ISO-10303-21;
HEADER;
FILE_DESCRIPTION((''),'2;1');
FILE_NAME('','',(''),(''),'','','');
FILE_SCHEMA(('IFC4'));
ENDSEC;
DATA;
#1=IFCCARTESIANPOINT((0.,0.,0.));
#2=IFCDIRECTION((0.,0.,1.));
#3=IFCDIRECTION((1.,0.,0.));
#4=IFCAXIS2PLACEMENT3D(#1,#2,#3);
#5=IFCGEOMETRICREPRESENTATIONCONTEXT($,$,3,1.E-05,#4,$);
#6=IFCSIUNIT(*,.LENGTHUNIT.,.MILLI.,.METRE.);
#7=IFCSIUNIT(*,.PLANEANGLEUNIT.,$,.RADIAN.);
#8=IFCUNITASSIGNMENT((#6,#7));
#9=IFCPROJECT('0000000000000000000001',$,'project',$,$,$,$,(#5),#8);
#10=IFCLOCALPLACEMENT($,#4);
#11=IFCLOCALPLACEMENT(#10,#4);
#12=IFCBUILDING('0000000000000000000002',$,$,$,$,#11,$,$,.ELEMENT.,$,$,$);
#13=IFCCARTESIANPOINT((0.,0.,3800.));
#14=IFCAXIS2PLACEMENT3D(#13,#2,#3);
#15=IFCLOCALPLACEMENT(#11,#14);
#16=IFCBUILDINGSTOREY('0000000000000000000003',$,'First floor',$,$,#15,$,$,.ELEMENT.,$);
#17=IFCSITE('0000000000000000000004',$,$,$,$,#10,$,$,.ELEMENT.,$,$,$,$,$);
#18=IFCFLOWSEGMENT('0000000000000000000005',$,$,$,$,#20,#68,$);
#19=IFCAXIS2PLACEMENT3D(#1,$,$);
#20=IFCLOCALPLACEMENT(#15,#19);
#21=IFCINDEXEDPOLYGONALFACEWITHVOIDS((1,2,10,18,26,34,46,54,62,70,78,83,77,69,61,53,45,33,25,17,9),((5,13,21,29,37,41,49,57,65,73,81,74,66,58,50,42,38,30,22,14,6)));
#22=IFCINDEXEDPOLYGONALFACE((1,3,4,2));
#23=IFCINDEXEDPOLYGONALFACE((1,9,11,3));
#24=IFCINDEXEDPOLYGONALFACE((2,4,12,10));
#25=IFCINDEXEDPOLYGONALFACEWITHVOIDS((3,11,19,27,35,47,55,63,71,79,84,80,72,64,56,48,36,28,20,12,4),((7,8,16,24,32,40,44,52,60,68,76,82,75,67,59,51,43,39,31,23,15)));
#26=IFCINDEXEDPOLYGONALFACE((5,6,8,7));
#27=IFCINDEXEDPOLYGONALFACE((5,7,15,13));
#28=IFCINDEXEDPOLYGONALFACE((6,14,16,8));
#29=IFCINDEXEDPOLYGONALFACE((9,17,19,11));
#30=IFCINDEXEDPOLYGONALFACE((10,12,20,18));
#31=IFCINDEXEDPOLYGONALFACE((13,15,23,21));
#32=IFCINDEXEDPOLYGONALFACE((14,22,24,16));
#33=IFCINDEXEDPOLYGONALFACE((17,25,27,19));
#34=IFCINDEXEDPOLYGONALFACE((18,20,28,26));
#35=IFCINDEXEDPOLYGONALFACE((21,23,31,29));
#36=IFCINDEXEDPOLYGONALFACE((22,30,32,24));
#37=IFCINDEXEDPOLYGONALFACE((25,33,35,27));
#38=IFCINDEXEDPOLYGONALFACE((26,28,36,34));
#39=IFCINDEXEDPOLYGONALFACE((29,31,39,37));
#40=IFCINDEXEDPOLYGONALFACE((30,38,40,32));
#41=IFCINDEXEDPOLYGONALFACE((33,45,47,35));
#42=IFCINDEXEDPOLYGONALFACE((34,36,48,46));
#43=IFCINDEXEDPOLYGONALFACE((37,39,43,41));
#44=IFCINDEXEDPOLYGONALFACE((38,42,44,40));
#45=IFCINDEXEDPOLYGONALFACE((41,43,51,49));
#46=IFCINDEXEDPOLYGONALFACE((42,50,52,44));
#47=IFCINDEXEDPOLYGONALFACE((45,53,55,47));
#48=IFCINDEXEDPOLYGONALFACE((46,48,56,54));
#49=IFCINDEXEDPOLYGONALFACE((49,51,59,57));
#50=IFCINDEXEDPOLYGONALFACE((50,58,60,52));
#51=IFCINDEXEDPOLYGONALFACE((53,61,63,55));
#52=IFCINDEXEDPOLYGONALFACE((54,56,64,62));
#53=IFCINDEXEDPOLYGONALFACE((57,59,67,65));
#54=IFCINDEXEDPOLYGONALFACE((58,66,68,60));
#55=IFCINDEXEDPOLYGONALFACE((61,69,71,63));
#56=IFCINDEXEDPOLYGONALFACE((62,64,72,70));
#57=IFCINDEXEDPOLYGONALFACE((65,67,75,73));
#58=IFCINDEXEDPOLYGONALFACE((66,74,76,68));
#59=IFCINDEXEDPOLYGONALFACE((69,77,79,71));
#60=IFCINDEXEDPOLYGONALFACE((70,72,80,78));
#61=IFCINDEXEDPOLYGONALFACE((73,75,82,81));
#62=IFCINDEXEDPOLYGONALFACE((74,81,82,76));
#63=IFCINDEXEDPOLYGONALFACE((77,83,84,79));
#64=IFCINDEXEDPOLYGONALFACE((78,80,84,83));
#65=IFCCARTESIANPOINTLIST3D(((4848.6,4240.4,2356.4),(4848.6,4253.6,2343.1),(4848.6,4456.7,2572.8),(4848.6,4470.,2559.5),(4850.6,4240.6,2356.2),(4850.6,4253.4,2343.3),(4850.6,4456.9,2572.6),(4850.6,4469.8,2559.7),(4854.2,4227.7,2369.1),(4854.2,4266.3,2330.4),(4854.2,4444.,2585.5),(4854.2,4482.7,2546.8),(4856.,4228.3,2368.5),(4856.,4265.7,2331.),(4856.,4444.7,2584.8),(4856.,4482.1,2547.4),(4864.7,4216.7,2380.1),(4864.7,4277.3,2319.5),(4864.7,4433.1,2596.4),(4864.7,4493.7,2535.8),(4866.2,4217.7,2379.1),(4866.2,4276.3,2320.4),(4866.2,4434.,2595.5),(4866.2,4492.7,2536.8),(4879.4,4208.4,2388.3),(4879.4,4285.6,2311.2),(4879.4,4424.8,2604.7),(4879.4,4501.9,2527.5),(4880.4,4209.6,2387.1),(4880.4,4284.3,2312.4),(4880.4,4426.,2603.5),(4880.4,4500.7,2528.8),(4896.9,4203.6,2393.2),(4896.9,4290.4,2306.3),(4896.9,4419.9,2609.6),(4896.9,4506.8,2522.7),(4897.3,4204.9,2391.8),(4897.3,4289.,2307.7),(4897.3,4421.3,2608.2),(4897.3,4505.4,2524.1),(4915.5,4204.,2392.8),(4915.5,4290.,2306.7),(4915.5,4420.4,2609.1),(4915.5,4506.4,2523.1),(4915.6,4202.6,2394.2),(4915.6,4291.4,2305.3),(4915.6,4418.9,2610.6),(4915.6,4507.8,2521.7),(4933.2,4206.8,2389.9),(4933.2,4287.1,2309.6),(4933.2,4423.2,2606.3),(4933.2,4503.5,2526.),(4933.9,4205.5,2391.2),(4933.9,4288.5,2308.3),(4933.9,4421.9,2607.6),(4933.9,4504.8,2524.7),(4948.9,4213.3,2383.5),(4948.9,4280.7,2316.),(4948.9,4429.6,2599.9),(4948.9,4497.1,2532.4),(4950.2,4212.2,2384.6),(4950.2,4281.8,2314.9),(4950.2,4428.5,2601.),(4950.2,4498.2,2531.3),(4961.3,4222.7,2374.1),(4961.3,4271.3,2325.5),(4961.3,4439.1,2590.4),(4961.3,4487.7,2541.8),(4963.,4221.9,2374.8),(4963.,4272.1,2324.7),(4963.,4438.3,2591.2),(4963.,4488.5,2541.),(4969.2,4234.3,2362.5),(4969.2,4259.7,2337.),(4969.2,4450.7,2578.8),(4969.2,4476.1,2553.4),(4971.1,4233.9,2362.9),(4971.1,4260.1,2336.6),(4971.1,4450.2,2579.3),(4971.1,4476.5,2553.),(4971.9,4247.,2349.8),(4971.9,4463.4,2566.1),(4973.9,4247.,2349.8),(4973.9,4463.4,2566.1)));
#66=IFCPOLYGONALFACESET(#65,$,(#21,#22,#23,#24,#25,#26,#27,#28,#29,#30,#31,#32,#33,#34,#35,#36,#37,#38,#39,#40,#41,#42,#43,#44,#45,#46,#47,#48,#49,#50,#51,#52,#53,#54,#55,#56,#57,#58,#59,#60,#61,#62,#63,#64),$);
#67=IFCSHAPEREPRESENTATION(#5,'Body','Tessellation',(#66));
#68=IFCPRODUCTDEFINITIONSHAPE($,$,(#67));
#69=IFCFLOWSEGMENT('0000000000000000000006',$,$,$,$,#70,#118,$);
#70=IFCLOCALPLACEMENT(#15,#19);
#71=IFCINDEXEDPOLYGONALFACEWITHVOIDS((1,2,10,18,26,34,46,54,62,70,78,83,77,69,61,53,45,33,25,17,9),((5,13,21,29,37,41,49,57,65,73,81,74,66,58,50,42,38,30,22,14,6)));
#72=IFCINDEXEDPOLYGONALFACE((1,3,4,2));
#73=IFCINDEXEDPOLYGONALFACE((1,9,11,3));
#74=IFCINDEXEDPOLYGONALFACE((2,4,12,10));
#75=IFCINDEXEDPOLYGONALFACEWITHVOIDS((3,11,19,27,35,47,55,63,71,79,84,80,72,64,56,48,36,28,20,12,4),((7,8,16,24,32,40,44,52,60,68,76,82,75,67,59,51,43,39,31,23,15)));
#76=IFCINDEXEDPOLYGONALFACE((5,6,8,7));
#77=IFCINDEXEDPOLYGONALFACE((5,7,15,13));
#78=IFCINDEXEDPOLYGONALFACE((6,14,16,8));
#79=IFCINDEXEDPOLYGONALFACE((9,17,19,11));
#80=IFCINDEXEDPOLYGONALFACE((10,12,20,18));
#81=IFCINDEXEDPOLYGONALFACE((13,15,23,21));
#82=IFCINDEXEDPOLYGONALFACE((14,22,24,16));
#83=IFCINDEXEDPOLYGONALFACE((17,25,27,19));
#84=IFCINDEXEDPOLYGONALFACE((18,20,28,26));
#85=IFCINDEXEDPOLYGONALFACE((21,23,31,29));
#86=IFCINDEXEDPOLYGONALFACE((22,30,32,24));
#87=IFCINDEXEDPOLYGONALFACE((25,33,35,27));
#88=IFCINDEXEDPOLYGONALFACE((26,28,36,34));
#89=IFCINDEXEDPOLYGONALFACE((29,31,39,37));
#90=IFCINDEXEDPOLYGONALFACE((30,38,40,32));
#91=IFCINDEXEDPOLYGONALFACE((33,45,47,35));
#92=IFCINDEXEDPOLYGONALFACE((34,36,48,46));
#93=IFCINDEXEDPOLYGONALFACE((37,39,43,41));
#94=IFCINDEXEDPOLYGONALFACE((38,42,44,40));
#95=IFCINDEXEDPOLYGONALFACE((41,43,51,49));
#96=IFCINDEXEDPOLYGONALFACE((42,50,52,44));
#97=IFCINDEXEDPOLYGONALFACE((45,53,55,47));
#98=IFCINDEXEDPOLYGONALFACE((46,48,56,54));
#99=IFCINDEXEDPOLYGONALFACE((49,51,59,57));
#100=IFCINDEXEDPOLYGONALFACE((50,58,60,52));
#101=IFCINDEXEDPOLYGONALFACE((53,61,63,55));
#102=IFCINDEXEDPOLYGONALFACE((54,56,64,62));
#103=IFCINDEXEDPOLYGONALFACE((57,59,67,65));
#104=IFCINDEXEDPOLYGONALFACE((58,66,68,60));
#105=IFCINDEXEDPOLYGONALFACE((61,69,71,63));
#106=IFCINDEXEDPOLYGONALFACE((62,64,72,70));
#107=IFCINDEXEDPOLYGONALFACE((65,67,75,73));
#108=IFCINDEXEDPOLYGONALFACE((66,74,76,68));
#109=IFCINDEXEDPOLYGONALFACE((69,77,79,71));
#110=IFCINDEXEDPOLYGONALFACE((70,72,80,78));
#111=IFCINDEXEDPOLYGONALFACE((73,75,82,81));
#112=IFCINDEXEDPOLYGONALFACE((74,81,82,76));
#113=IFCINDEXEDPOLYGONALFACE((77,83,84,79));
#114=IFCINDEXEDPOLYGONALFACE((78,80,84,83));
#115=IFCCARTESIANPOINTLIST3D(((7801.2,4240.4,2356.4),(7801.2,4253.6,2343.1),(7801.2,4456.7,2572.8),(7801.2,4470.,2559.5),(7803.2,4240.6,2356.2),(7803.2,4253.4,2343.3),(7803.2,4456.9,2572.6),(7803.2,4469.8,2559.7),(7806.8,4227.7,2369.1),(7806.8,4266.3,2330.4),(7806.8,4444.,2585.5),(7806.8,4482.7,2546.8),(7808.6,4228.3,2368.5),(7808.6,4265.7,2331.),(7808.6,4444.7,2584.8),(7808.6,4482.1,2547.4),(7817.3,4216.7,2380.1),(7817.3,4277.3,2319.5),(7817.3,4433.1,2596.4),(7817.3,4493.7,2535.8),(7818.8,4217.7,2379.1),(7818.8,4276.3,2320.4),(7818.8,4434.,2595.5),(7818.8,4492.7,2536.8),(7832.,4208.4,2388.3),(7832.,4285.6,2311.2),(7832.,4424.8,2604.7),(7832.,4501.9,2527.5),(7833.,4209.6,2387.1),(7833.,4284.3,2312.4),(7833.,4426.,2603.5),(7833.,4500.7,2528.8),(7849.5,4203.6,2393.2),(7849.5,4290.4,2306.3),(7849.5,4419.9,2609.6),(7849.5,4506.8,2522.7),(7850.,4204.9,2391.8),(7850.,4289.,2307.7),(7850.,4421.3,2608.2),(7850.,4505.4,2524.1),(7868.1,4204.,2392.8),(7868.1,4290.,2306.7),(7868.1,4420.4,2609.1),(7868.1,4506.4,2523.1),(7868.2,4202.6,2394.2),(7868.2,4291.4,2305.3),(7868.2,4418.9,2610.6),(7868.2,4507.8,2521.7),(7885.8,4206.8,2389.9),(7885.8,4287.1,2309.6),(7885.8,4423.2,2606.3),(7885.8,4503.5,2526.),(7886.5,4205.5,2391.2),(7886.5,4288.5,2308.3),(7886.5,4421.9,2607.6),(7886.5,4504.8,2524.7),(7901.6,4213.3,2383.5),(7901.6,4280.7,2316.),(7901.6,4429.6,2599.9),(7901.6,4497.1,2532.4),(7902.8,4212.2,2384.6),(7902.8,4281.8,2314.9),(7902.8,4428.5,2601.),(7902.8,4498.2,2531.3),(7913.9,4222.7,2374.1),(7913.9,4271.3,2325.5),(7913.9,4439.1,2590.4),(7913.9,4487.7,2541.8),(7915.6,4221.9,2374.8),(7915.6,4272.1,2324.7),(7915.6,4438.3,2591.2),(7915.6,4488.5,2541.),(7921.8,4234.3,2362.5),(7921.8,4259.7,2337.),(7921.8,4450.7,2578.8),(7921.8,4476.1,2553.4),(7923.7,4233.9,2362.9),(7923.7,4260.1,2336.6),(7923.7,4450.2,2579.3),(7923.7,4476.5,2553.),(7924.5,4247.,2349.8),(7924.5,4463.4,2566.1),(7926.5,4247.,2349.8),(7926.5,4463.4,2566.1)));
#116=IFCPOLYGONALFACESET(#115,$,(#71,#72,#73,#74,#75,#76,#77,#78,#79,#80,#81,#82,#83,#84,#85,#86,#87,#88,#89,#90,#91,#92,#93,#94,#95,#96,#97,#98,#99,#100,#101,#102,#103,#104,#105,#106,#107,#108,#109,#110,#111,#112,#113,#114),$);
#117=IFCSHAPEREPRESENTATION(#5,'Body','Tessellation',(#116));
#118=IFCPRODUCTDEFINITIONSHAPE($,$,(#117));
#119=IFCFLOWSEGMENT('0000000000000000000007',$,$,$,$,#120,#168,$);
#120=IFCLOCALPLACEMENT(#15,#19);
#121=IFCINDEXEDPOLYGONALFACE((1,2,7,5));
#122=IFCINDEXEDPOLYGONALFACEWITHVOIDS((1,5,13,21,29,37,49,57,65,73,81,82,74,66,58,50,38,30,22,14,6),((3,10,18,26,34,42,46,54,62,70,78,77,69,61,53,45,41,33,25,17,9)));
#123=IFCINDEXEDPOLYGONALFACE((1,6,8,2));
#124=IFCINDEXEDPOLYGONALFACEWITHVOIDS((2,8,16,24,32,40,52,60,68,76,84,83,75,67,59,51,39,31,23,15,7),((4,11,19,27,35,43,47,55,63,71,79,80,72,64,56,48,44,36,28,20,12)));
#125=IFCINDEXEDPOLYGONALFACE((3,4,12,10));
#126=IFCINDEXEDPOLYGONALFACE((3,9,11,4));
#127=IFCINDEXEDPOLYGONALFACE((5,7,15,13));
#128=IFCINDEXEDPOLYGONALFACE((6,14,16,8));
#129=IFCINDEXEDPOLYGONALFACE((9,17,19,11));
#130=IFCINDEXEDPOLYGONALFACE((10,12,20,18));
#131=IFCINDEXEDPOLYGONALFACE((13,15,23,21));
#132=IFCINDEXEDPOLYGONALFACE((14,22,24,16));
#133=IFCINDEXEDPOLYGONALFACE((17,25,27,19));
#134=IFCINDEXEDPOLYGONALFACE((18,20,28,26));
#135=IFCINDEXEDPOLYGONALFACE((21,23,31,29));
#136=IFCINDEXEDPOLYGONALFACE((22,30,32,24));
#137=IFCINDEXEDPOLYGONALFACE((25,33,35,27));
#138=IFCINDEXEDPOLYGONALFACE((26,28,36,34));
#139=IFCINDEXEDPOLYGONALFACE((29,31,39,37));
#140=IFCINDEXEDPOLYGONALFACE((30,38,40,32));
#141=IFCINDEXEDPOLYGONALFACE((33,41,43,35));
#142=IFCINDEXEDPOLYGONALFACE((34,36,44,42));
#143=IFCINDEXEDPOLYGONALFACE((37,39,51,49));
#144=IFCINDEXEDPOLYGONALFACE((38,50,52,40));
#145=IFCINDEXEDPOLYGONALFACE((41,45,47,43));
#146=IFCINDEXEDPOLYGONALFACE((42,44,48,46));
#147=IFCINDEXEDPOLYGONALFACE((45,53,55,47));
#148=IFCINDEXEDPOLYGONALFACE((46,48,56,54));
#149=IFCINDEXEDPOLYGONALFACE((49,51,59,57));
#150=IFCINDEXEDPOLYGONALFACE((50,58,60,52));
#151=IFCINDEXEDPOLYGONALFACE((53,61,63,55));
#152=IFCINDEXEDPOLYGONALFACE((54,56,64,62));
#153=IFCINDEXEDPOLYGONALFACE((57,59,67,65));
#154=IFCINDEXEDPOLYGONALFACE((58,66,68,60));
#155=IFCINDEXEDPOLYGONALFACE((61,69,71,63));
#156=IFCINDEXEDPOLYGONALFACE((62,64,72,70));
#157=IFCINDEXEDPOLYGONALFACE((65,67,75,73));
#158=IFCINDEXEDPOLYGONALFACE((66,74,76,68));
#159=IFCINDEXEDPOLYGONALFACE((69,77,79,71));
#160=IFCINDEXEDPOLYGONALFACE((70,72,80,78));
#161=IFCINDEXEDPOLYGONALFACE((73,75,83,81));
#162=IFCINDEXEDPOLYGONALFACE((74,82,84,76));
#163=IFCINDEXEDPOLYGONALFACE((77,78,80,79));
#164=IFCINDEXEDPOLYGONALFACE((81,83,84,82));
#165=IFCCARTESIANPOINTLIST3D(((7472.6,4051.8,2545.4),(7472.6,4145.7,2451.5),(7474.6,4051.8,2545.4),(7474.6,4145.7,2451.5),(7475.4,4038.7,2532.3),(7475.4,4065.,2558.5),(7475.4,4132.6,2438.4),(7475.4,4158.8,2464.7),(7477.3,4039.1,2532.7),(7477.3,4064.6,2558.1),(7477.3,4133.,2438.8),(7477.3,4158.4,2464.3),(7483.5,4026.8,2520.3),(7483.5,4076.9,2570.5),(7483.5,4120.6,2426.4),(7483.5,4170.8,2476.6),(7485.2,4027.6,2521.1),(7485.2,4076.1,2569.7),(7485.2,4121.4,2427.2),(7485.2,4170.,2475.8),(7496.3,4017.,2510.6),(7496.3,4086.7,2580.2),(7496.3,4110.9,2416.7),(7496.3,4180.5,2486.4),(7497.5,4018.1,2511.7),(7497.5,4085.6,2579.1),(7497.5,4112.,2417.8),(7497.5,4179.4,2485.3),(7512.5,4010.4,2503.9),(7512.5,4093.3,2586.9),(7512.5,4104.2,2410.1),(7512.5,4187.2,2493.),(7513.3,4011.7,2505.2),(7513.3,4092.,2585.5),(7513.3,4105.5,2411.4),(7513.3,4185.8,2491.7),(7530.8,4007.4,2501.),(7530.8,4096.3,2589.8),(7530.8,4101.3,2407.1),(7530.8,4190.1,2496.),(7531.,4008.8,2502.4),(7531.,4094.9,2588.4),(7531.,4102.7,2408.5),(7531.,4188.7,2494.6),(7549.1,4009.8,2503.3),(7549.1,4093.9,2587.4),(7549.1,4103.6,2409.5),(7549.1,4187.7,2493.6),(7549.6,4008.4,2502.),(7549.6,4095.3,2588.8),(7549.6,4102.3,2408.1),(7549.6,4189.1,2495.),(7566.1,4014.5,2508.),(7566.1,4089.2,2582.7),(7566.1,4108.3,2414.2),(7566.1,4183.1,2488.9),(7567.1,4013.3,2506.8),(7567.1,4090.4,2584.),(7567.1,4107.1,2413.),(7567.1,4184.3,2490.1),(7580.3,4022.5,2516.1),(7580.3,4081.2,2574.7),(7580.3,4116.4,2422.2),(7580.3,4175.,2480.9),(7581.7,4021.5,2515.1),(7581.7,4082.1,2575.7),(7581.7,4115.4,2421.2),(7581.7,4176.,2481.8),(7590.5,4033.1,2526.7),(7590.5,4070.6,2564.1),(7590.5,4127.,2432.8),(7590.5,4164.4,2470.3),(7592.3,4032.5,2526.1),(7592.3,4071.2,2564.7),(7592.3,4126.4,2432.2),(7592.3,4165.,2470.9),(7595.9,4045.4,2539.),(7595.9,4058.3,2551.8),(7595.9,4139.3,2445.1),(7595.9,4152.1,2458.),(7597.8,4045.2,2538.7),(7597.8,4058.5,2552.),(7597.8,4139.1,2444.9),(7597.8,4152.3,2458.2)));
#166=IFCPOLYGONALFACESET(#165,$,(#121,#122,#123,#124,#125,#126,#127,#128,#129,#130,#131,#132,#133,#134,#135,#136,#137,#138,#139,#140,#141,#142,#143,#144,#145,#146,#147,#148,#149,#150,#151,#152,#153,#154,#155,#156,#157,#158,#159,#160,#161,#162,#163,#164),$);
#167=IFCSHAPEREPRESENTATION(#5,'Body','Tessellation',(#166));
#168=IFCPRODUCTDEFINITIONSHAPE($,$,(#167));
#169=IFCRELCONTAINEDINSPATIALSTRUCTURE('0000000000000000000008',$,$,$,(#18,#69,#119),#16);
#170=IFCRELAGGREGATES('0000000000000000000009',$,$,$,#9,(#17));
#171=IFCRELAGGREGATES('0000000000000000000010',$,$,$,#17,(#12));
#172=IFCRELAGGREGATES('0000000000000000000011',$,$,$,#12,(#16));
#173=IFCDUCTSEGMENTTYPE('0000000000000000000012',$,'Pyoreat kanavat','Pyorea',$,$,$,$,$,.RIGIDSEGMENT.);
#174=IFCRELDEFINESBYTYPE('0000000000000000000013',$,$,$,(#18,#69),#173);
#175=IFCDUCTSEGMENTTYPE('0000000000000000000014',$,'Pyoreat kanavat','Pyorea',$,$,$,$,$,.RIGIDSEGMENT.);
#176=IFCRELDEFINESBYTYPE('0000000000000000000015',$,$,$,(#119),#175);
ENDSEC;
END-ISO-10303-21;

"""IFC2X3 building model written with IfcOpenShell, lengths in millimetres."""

from ifc_helpers import new_model, si_unit, frame, origin_with_axes, origin_2d_with_axis, place, context, project, spatial, hollow_circle, extrude, source, transform, mapped, type_object, element, save


model = new_model("IFC2X3")

# Units and contexts
context_of_model = context(None, 3, precision=1e-05, world=origin_with_axes())
ifc_project = project(units=[si_unit("LENGTHUNIT", "METRE", prefix="MILLI"), si_unit("PLANEANGLEUNIT", "RADIAN")], contexts=[context_of_model])

# Site, building, storey
site_placement = place(None, origin_with_axes())
site = spatial("IfcSite", under=ifc_project, at=site_placement, CompositionType="ELEMENT")
building_placement = place(site_placement, origin_with_axes())
building = spatial("IfcBuilding", under=site, at=building_placement, CompositionType="ELEMENT")
storey_placement = place(building_placement, frame((0.0, 0.0, 3800.0), z_axis=(0.0, 0.0, 1.0), x_axis=(1.0, 0.0, 0.0)))
storey = spatial("IfcBuildingStorey", under=building, at=storey_placement, Name="First floor", CompositionType="ELEMENT")

# Flow segments
duct_segment_type_1 = type_object("IfcDuctSegmentType", Name="Pyoreat kanavat", Description="Pyorea", PredefinedType="RIGIDSEGMENT")
shared_shape_1 = source(origin_with_axes(), context_of_model, "Body", "SweptSolid", [
    extrude(hollow_circle(Radius=63.0, WallThickness=2.0, at=origin_2d_with_axis()), frame((0.0, 0.0, 0.0), z_axis=(1.0, 0.0, 0.0), x_axis=(0.0, 1.0, 0.0)), (0.0, 0.0, 1.0), 306.0),
])
flow_segment_1_placement = place(storey_placement, frame((4910.9, 4463.4, 2566.1), z_axis=(0.0, -0.707107, 0.707107), x_axis=(0.0, -0.707107, -0.707107)))
element("IfcFlowSegment", 1, at=flow_segment_1_placement, inside=storey, type_object=duct_segment_type_1, context=context_of_model, shape_type="MappedRepresentation", body=[
    mapped(shared_shape_1, transform((0.0, 0.0, 0.0), scale=1.0)),
])
shared_shape_2 = source(origin_with_axes(), context_of_model, "Body", "SweptSolid", [
    extrude(hollow_circle(Radius=63.0, WallThickness=2.0, at=origin_2d_with_axis()), frame((0.0, 0.0, 0.0), z_axis=(1.0, 0.0, 0.0), x_axis=(0.0, 1.0, 0.0)), (0.0, 0.0, 1.0), 306.0),
])
flow_segment_2_placement = place(storey_placement, frame((7863.5, 4463.4, 2566.1), z_axis=(0.0, -0.707107, 0.707107), x_axis=(0.0, -0.707107, -0.707107)))
element("IfcFlowSegment", 2, at=flow_segment_2_placement, inside=storey, type_object=duct_segment_type_1, context=context_of_model, shape_type="MappedRepresentation", body=[
    mapped(shared_shape_2, transform((0.0, 0.0, 0.0), scale=1.0)),
])
duct_segment_type_2 = type_object("IfcDuctSegmentType", Name="Pyoreat kanavat", Description="Pyorea", PredefinedType="RIGIDSEGMENT")
shared_shape_3 = source(origin_with_axes(), context_of_model, "Body", "SweptSolid", [
    extrude(hollow_circle(Radius=63.0, WallThickness=2.0, at=origin_2d_with_axis()), frame((0.0, 0.0, 0.0), z_axis=(1.0, 0.0, 0.0), x_axis=(0.0, 1.0, 0.0)), (0.0, 0.0, 1.0), 306.0),
])
flow_segment_3_placement = place(storey_placement, frame((7535.6, 4051.8, 2545.4), z_axis=(0.0, 0.707107, 0.707107), x_axis=(0.0, 0.707107, -0.707107)))
element("IfcFlowSegment", 3, at=flow_segment_3_placement, inside=storey, type_object=duct_segment_type_2, context=context_of_model, shape_type="MappedRepresentation", body=[
    mapped(shared_shape_3, transform((0.0, 0.0, 0.0), scale=0.43373, scale2=1.0, scale3=1.0, uniform=False)),
])

save(model, "model.ifc")
